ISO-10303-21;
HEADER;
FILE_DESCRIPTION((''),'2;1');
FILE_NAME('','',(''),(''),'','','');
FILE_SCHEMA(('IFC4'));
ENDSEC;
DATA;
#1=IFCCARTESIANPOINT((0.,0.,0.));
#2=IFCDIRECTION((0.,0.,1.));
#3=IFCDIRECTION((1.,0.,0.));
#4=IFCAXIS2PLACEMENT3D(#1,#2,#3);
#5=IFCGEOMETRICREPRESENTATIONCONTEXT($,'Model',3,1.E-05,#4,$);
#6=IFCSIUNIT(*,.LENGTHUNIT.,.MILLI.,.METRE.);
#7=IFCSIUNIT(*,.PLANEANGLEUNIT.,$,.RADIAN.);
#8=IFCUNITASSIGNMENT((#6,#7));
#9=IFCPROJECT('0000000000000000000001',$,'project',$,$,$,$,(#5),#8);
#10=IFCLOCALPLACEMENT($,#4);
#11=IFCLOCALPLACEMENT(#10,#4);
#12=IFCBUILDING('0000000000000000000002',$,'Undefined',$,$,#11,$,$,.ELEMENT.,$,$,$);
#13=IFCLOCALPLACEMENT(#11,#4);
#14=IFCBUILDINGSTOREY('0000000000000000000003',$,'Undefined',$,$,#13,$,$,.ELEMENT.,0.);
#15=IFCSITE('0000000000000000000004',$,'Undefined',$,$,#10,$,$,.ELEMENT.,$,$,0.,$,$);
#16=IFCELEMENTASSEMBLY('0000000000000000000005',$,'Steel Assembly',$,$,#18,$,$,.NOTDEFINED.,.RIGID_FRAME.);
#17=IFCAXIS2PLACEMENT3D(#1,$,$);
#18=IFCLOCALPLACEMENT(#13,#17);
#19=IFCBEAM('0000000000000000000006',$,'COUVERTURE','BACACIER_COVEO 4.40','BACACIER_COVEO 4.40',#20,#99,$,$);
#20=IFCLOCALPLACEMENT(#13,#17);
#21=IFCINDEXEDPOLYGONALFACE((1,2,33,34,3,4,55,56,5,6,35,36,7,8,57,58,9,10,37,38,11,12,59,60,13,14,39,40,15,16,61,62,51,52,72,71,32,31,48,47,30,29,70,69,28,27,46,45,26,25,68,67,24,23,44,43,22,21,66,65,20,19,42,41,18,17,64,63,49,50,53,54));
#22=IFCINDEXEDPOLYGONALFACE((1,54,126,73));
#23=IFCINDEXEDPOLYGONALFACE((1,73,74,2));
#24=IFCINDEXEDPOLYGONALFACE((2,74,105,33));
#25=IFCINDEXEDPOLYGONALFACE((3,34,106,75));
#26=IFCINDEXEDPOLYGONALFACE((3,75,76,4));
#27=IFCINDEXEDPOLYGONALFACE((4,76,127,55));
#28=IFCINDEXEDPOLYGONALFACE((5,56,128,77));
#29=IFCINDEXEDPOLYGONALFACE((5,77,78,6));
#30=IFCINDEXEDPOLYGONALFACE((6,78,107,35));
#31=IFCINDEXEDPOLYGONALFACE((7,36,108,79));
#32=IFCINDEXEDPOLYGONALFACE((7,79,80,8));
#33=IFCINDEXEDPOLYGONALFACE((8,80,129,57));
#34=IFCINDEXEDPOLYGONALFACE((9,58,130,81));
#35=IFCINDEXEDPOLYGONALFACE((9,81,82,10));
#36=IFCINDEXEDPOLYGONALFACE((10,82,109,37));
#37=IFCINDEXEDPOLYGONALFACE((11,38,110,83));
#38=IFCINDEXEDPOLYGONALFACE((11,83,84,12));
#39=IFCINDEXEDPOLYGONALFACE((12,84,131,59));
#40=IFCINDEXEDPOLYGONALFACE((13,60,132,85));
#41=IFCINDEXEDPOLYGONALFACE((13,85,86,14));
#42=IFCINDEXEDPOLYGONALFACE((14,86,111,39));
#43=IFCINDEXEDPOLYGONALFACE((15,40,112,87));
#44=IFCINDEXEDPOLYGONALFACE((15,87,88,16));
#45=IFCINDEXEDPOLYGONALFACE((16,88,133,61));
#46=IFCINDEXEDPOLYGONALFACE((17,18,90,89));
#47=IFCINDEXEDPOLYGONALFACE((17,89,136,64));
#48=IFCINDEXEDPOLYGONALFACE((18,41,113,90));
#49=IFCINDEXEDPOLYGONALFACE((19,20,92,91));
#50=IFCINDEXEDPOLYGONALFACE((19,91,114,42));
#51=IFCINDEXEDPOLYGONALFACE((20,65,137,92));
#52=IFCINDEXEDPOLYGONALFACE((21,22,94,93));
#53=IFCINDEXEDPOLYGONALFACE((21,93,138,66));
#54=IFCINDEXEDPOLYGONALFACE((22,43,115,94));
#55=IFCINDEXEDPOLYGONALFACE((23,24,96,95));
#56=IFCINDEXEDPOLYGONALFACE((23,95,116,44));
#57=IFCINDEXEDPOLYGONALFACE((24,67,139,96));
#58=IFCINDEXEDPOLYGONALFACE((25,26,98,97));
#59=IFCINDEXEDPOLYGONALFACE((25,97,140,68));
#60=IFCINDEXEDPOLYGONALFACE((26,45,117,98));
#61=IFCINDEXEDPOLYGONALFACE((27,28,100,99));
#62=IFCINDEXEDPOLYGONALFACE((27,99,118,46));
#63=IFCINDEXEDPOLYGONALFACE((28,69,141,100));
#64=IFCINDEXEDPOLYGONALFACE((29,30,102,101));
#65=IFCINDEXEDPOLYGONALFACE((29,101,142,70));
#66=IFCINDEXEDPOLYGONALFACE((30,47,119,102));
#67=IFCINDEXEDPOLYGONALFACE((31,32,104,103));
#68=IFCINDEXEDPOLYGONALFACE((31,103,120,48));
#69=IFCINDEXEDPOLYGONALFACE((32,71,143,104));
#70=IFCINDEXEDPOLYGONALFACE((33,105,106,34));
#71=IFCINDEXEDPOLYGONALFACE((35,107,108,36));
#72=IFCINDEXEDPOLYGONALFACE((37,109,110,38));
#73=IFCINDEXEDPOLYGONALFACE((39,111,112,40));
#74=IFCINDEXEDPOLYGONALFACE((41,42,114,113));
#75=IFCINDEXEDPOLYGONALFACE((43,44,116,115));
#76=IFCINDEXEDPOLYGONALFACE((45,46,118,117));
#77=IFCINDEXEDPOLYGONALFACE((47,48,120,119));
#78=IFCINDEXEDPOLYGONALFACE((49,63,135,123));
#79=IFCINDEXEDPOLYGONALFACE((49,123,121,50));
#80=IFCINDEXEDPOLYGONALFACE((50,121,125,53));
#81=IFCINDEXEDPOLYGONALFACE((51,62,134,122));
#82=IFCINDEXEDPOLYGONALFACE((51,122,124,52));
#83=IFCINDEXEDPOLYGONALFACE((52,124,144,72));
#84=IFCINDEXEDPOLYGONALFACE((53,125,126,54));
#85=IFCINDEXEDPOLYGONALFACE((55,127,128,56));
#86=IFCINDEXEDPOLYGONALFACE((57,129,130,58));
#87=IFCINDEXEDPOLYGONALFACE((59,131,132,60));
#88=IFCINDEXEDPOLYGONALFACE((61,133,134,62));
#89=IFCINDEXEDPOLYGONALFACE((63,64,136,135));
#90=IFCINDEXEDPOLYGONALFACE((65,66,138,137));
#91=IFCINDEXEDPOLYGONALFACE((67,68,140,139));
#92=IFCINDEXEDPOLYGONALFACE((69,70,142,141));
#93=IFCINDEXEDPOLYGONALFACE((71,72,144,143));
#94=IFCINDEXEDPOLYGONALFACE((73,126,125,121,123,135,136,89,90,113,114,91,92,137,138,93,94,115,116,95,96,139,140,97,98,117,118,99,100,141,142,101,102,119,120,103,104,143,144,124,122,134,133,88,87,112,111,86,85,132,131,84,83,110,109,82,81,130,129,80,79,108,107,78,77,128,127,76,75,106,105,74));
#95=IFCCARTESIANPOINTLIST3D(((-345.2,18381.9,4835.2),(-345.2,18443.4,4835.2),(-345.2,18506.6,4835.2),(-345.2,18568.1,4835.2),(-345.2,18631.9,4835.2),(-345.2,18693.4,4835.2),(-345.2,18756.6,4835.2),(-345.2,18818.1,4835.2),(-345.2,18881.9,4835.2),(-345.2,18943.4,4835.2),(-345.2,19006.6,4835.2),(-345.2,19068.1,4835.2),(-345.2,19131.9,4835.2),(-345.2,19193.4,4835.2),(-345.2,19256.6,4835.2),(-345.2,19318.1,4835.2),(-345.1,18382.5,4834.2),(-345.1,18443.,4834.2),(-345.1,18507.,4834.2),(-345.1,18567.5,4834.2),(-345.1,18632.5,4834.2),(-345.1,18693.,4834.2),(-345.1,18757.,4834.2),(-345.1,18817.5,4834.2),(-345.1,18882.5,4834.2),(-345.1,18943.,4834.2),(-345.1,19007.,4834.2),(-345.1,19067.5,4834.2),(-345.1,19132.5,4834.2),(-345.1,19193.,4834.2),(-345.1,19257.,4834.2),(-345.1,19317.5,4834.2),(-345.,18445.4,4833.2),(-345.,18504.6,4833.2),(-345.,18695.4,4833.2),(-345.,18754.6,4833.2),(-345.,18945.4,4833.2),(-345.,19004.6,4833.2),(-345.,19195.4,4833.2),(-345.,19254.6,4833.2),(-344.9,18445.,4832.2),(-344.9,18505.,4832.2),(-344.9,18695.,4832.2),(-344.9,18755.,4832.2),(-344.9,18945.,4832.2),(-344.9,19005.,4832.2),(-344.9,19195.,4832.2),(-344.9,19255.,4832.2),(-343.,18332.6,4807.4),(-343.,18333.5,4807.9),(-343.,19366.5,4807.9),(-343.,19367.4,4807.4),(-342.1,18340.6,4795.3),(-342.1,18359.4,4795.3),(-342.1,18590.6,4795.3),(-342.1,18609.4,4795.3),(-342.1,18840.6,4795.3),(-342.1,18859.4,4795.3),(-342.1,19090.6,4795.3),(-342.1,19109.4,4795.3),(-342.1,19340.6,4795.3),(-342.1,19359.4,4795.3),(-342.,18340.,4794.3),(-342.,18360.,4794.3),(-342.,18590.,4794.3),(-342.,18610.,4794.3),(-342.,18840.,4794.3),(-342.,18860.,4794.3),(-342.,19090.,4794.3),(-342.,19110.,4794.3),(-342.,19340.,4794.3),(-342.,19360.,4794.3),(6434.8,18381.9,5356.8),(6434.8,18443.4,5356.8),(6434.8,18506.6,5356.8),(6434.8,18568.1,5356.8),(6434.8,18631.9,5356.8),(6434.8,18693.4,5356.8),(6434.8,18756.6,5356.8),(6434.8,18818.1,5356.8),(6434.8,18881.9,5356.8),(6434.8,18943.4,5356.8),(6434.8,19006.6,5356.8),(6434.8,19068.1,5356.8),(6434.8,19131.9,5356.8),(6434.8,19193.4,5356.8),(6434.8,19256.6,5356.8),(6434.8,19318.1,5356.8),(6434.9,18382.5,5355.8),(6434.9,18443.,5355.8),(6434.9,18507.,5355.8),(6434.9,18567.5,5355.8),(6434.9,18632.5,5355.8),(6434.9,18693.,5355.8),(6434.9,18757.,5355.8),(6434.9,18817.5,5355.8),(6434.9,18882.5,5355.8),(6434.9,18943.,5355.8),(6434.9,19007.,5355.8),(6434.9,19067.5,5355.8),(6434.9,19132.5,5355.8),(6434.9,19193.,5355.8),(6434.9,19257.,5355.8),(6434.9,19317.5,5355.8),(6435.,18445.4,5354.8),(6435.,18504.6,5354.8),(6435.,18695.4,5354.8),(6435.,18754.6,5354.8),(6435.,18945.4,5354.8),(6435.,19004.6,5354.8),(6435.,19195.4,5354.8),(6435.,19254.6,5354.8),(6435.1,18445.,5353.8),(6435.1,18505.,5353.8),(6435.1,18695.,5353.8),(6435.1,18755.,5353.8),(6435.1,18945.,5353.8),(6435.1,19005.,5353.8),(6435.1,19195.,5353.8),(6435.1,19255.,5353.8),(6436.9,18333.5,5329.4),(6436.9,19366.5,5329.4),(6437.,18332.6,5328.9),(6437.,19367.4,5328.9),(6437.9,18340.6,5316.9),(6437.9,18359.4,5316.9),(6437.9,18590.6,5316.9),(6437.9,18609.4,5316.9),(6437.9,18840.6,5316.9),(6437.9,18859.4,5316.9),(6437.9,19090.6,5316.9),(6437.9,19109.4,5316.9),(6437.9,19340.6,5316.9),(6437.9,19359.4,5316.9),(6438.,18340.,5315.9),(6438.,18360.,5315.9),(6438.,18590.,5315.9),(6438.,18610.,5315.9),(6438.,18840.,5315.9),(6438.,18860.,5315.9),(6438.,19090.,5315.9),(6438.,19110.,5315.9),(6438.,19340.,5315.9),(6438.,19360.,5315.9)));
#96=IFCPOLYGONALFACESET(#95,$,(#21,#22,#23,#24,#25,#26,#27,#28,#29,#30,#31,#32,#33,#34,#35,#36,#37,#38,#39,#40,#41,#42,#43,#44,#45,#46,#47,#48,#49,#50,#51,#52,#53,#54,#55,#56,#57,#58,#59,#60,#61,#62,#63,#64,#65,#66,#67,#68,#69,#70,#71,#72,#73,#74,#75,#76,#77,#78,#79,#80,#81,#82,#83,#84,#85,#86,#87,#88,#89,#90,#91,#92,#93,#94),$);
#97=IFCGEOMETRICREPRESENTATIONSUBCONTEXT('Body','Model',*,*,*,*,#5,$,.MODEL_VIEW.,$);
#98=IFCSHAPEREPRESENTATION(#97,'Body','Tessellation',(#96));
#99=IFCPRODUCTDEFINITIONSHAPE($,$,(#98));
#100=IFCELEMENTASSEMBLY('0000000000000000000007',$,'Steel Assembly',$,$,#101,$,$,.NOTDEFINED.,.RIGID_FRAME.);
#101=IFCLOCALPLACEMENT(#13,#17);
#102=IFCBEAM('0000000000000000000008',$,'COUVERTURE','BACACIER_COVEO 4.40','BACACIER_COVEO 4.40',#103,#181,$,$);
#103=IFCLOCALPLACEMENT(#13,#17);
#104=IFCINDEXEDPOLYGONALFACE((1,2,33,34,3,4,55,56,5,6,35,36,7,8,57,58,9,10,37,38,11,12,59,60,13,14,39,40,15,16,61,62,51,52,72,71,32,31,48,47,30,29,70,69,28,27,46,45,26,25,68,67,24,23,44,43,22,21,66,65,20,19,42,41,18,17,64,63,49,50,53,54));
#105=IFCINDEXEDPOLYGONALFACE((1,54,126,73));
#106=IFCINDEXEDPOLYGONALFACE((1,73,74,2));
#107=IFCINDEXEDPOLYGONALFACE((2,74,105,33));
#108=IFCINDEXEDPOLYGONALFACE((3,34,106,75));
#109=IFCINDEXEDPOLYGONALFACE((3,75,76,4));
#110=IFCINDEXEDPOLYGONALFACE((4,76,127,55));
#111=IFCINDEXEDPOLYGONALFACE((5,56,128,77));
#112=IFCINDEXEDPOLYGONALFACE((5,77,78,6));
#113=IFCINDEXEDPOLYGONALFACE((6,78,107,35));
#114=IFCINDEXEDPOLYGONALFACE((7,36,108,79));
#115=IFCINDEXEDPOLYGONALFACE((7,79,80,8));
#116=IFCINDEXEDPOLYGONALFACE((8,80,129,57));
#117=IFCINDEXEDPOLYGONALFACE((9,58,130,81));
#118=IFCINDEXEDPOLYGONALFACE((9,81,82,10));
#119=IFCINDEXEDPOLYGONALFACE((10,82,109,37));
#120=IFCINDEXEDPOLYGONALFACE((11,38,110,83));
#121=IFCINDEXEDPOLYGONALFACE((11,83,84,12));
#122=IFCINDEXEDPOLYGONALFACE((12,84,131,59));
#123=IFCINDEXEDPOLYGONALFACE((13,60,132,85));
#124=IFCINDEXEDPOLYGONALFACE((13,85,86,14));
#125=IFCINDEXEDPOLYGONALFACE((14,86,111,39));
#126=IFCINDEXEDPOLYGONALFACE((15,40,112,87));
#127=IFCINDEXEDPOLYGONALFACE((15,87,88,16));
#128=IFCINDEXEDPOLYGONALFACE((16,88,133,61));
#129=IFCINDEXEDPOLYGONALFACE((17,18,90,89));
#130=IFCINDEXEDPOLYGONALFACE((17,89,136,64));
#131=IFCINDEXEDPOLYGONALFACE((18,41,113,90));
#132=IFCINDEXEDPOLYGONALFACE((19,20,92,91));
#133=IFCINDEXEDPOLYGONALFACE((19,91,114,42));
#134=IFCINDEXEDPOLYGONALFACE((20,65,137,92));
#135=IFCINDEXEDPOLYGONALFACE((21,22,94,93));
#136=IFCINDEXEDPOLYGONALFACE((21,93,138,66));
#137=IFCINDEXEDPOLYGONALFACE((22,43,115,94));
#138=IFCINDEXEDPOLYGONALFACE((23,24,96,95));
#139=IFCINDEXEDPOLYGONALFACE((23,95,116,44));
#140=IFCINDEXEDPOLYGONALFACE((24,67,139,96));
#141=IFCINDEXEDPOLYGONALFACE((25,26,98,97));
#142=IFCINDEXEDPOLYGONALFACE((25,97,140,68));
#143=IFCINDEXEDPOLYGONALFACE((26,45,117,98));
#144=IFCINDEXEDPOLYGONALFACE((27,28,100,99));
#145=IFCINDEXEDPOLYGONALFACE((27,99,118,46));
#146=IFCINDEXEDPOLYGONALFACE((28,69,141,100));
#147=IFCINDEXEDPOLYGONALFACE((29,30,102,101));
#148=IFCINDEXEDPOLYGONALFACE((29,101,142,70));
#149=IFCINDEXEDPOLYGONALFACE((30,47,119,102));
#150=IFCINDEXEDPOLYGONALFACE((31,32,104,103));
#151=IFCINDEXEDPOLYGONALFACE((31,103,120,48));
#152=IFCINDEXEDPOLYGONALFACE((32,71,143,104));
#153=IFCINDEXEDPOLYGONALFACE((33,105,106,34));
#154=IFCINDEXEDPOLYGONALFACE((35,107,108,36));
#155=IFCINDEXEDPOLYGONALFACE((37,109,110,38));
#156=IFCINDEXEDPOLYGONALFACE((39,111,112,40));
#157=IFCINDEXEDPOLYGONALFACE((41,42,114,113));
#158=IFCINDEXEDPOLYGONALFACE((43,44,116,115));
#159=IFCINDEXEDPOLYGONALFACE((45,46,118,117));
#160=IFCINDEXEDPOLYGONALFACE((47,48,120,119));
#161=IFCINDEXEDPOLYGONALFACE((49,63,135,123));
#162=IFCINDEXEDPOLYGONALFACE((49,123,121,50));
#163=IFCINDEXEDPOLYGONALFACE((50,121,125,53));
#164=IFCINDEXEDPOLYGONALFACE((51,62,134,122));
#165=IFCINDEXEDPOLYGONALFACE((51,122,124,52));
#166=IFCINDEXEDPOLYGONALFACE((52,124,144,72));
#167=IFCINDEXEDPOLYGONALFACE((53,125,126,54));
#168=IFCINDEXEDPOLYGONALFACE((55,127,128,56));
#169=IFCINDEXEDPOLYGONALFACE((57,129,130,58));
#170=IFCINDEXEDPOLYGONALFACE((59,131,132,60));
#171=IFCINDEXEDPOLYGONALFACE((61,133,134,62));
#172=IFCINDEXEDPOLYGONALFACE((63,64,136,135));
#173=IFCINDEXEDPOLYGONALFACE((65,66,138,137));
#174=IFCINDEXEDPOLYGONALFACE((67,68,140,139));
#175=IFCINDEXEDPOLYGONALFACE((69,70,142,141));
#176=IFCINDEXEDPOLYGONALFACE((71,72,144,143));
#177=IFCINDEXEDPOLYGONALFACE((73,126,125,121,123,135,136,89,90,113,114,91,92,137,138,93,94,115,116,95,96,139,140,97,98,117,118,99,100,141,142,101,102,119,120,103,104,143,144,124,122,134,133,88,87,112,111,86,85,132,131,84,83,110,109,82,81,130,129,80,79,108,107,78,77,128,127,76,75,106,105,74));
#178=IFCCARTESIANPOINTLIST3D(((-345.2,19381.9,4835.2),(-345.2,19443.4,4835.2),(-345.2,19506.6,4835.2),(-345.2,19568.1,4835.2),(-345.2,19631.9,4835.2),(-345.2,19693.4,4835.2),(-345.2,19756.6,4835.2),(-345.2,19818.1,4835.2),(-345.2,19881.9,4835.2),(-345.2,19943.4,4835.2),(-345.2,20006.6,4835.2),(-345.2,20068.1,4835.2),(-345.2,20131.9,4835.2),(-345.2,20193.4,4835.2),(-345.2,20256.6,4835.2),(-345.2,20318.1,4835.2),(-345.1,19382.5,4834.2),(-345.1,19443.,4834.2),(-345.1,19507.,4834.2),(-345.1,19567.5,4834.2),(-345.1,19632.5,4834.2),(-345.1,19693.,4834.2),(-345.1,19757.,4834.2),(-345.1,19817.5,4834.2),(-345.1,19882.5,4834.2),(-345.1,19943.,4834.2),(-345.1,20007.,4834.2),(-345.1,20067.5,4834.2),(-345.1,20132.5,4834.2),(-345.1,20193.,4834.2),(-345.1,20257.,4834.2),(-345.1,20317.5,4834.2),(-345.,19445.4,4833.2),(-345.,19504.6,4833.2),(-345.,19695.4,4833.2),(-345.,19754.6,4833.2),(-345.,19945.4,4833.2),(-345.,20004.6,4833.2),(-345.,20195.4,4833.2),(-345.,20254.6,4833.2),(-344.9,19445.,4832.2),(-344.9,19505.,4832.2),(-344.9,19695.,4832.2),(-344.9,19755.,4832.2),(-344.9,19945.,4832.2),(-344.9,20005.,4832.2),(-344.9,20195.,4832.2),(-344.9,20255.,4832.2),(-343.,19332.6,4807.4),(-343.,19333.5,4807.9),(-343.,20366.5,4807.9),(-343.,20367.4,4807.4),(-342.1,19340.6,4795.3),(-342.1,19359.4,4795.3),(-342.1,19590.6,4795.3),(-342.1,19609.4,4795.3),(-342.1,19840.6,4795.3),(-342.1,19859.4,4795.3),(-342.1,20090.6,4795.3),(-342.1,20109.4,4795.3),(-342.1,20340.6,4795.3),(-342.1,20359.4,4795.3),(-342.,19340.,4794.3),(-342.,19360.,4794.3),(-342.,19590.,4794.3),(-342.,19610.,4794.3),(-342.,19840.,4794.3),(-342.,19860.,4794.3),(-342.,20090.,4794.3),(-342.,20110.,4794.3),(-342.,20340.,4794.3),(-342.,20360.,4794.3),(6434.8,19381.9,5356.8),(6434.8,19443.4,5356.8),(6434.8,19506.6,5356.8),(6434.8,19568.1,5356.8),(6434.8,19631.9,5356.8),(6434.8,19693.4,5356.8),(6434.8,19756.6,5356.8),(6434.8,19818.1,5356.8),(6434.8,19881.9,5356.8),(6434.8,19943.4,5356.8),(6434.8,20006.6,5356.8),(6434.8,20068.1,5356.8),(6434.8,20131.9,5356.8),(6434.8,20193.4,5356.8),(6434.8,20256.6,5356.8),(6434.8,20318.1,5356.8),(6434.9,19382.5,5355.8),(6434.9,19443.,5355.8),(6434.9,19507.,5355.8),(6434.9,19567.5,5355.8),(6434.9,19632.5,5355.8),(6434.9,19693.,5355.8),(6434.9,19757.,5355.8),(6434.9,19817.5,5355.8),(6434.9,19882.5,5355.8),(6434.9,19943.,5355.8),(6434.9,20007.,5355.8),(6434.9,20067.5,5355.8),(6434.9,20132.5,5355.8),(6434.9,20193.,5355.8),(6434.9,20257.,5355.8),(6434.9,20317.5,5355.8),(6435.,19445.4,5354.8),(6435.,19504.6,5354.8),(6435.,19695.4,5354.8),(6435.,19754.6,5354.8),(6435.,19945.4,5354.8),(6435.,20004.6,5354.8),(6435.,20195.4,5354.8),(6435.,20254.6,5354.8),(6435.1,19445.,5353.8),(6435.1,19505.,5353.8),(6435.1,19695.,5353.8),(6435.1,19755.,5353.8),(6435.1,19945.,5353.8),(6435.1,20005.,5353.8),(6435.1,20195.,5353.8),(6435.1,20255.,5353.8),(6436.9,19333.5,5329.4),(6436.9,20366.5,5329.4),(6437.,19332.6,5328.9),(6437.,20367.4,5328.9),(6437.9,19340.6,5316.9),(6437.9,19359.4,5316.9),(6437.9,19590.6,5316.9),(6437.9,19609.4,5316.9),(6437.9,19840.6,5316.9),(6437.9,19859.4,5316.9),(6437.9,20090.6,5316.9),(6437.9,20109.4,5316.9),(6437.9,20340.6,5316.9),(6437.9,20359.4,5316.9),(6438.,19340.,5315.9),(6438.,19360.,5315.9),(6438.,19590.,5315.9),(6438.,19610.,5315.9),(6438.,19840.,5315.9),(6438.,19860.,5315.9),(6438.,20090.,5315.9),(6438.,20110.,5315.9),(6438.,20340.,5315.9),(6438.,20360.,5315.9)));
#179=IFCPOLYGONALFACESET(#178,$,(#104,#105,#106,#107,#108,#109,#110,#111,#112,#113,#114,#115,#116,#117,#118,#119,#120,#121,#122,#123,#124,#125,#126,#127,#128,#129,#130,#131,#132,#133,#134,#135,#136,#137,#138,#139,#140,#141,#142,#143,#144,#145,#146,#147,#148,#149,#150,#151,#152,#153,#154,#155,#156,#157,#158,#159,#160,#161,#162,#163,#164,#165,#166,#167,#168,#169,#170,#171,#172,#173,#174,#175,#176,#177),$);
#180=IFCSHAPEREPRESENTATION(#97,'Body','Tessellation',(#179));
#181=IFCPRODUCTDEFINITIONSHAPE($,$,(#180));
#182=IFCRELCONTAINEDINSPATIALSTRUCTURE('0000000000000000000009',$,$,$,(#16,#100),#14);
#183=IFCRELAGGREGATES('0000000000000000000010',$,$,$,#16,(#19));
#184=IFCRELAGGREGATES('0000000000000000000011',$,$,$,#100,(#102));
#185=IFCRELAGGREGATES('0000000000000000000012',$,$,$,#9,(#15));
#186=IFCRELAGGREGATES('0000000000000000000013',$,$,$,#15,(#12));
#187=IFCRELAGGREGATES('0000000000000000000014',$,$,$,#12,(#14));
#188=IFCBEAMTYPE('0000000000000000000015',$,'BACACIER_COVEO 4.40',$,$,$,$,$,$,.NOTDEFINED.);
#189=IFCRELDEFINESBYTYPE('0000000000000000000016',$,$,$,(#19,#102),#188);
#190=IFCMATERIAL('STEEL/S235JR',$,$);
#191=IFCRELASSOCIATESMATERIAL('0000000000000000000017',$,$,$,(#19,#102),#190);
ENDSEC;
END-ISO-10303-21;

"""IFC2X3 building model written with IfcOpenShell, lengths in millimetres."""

from ifc_helpers import new_model, si_unit, frame, origin_with_axes, place, context, subcontext, project, spatial, polyline, outline, extrude, material, type_object, element, aggregate, save


model = new_model("IFC2X3")

# Units and contexts
model_context = context("Model", 3, precision=1e-05, world=origin_with_axes())
body_context = subcontext(model_context, "Body", "Model", "MODEL_VIEW")
ifc_project = project(units=[si_unit("LENGTHUNIT", "METRE", prefix="MILLI"), si_unit("PLANEANGLEUNIT", "RADIAN")], contexts=[model_context])

# Site, building, storey
site_placement = place(None, origin_with_axes())
site = spatial("IfcSite", under=ifc_project, at=site_placement, Name="Undefined", CompositionType="ELEMENT", RefElevation=0.0)
building_placement = place(site_placement, origin_with_axes())
building = spatial("IfcBuilding", under=site, at=building_placement, Name="Undefined", CompositionType="ELEMENT")
storey_placement = place(building_placement, origin_with_axes())
storey = spatial("IfcBuildingStorey", under=building, at=storey_placement, Name="Undefined", CompositionType="ELEMENT", Elevation=0.0)

# Element assemblies, beams
assembly_1_placement = place(storey_placement, origin_with_axes())
assembly_1 = element("IfcElementAssembly", 1, at=assembly_1_placement, inside=storey, Name="Steel Assembly", AssemblyPlace="NOTDEFINED", PredefinedType="RIGID_FRAME")
ifc_material_1 = material(Name="STEEL/S235JR")
beam_type_1 = type_object("IfcBeamType", Name="BACACIER_COVEO 4.40", PredefinedType="NOTDEFINED")
beam_1_placement = place(assembly_1_placement, frame((6436.4, 18850.0, 5336.3), z_axis=(0.076696, 0.0, -0.997054), x_axis=(-0.997054, 0.0, -0.076696)))
beam_1 = element("IfcBeam", 2, at=beam_1_placement, type_object=beam_type_1, material=ifc_material_1, Name="COUVERTURE", Description="BACACIER_COVEO 4.40", ObjectType="BACACIER_COVEO 4.40", context=body_context, shape_type="SweptSolid", body=[
    extrude(outline(polyline([(509.4, 19.5), (490.6, 19.5), (468.1, -20.5), (406.6, -20.5), (404.6, -18.5), (345.4, -18.5), (343.4, -20.5), (281.9, -20.5), (259.4, 19.5), (240.6, 19.5), (218.1, -20.5), (156.6, -20.5), (154.6, -18.5), (95.4, -18.5), (93.4, -20.5), (31.9, -20.5), (9.4, 19.5), (-9.4, 19.5), (-31.9, -20.5), (-93.4, -20.5), (-95.4, -18.5), (-154.6, -18.5), (-156.6, -20.5), (-218.1, -20.5), (-240.6, 19.5), (-259.4, 19.5), (-281.9, -20.5), (-343.4, -20.5), (-345.4, -18.5), (-404.6, -18.5), (-406.6, -20.5), (-468.1, -20.5), (-490.6, 19.5), (-509.4, 19.5), (-516.5, 6.9), (-517.4, 7.4), (-510.0, 20.5), (-490.0, 20.5), (-467.5, -19.5), (-407.0, -19.5), (-405.0, -17.5), (-345.0, -17.5), (-343.0, -19.5), (-282.5, -19.5), (-260.0, 20.5), (-240.0, 20.5), (-217.5, -19.5), (-157.0, -19.5), (-155.0, -17.5), (-95.0, -17.5), (-93.0, -19.5), (-32.5, -19.5), (-10.0, 20.5), (10.0, 20.5), (32.5, -19.5), (93.0, -19.5), (95.0, -17.5), (155.0, -17.5), (157.0, -19.5), (217.5, -19.5), (240.0, 20.5), (260.0, 20.5), (282.5, -19.5), (343.0, -19.5), (345.0, -17.5), (405.0, -17.5), (407.0, -19.5), (467.5, -19.5), (490.0, 20.5), (510.0, 20.5), (517.4, 7.4), (516.5, 6.9), (509.4, 19.5)])), frame((6800.0, 0.0, 0.0), z_axis=(-1.0, 0.0, 0.0), x_axis=(0.0, -1.0, 0.0)), (0.0, 0.0, 1.0), 6800.0),
])
aggregate(assembly_1, [beam_1])
assembly_2_placement = place(storey_placement, origin_with_axes())
assembly_2 = element("IfcElementAssembly", 3, at=assembly_2_placement, inside=storey, Name="Steel Assembly", AssemblyPlace="NOTDEFINED", PredefinedType="RIGID_FRAME")
beam_2_placement = place(assembly_2_placement, frame((6436.4, 19850.0, 5336.3), z_axis=(0.076696, 0.0, -0.997054), x_axis=(-0.997054, 0.0, -0.076696)))
beam_2 = element("IfcBeam", 4, at=beam_2_placement, type_object=beam_type_1, material=ifc_material_1, Name="COUVERTURE", Description="BACACIER_COVEO 4.40", ObjectType="BACACIER_COVEO 4.40", context=body_context, shape_type="SweptSolid", body=[
    extrude(outline(polyline([(509.4, 19.5), (490.6, 19.5), (468.1, -20.5), (406.6, -20.5), (404.6, -18.5), (345.4, -18.5), (343.4, -20.5), (281.9, -20.5), (259.4, 19.5), (240.6, 19.5), (218.1, -20.5), (156.6, -20.5), (154.6, -18.5), (95.4, -18.5), (93.4, -20.5), (31.9, -20.5), (9.4, 19.5), (-9.4, 19.5), (-31.9, -20.5), (-93.4, -20.5), (-95.4, -18.5), (-154.6, -18.5), (-156.6, -20.5), (-218.1, -20.5), (-240.6, 19.5), (-259.4, 19.5), (-281.9, -20.5), (-343.4, -20.5), (-345.4, -18.5), (-404.6, -18.5), (-406.6, -20.5), (-468.1, -20.5), (-490.6, 19.5), (-509.4, 19.5), (-516.5, 6.9), (-517.4, 7.4), (-510.0, 20.5), (-490.0, 20.5), (-467.5, -19.5), (-407.0, -19.5), (-405.0, -17.5), (-345.0, -17.5), (-343.0, -19.5), (-282.5, -19.5), (-260.0, 20.5), (-240.0, 20.5), (-217.5, -19.5), (-157.0, -19.5), (-155.0, -17.5), (-95.0, -17.5), (-93.0, -19.5), (-32.5, -19.5), (-10.0, 20.5), (10.0, 20.5), (32.5, -19.5), (93.0, -19.5), (95.0, -17.5), (155.0, -17.5), (157.0, -19.5), (217.5, -19.5), (240.0, 20.5), (260.0, 20.5), (282.5, -19.5), (343.0, -19.5), (345.0, -17.5), (405.0, -17.5), (407.0, -19.5), (467.5, -19.5), (490.0, 20.5), (510.0, 20.5), (517.4, 7.4), (516.5, 6.9), (509.4, 19.5)])), frame((6800.0, 0.0, 0.0), z_axis=(-1.0, 0.0, 0.0), x_axis=(0.0, -1.0, 0.0)), (0.0, 0.0, 1.0), 6800.0),
])
aggregate(assembly_2, [beam_2])

save(model, "model.ifc")
